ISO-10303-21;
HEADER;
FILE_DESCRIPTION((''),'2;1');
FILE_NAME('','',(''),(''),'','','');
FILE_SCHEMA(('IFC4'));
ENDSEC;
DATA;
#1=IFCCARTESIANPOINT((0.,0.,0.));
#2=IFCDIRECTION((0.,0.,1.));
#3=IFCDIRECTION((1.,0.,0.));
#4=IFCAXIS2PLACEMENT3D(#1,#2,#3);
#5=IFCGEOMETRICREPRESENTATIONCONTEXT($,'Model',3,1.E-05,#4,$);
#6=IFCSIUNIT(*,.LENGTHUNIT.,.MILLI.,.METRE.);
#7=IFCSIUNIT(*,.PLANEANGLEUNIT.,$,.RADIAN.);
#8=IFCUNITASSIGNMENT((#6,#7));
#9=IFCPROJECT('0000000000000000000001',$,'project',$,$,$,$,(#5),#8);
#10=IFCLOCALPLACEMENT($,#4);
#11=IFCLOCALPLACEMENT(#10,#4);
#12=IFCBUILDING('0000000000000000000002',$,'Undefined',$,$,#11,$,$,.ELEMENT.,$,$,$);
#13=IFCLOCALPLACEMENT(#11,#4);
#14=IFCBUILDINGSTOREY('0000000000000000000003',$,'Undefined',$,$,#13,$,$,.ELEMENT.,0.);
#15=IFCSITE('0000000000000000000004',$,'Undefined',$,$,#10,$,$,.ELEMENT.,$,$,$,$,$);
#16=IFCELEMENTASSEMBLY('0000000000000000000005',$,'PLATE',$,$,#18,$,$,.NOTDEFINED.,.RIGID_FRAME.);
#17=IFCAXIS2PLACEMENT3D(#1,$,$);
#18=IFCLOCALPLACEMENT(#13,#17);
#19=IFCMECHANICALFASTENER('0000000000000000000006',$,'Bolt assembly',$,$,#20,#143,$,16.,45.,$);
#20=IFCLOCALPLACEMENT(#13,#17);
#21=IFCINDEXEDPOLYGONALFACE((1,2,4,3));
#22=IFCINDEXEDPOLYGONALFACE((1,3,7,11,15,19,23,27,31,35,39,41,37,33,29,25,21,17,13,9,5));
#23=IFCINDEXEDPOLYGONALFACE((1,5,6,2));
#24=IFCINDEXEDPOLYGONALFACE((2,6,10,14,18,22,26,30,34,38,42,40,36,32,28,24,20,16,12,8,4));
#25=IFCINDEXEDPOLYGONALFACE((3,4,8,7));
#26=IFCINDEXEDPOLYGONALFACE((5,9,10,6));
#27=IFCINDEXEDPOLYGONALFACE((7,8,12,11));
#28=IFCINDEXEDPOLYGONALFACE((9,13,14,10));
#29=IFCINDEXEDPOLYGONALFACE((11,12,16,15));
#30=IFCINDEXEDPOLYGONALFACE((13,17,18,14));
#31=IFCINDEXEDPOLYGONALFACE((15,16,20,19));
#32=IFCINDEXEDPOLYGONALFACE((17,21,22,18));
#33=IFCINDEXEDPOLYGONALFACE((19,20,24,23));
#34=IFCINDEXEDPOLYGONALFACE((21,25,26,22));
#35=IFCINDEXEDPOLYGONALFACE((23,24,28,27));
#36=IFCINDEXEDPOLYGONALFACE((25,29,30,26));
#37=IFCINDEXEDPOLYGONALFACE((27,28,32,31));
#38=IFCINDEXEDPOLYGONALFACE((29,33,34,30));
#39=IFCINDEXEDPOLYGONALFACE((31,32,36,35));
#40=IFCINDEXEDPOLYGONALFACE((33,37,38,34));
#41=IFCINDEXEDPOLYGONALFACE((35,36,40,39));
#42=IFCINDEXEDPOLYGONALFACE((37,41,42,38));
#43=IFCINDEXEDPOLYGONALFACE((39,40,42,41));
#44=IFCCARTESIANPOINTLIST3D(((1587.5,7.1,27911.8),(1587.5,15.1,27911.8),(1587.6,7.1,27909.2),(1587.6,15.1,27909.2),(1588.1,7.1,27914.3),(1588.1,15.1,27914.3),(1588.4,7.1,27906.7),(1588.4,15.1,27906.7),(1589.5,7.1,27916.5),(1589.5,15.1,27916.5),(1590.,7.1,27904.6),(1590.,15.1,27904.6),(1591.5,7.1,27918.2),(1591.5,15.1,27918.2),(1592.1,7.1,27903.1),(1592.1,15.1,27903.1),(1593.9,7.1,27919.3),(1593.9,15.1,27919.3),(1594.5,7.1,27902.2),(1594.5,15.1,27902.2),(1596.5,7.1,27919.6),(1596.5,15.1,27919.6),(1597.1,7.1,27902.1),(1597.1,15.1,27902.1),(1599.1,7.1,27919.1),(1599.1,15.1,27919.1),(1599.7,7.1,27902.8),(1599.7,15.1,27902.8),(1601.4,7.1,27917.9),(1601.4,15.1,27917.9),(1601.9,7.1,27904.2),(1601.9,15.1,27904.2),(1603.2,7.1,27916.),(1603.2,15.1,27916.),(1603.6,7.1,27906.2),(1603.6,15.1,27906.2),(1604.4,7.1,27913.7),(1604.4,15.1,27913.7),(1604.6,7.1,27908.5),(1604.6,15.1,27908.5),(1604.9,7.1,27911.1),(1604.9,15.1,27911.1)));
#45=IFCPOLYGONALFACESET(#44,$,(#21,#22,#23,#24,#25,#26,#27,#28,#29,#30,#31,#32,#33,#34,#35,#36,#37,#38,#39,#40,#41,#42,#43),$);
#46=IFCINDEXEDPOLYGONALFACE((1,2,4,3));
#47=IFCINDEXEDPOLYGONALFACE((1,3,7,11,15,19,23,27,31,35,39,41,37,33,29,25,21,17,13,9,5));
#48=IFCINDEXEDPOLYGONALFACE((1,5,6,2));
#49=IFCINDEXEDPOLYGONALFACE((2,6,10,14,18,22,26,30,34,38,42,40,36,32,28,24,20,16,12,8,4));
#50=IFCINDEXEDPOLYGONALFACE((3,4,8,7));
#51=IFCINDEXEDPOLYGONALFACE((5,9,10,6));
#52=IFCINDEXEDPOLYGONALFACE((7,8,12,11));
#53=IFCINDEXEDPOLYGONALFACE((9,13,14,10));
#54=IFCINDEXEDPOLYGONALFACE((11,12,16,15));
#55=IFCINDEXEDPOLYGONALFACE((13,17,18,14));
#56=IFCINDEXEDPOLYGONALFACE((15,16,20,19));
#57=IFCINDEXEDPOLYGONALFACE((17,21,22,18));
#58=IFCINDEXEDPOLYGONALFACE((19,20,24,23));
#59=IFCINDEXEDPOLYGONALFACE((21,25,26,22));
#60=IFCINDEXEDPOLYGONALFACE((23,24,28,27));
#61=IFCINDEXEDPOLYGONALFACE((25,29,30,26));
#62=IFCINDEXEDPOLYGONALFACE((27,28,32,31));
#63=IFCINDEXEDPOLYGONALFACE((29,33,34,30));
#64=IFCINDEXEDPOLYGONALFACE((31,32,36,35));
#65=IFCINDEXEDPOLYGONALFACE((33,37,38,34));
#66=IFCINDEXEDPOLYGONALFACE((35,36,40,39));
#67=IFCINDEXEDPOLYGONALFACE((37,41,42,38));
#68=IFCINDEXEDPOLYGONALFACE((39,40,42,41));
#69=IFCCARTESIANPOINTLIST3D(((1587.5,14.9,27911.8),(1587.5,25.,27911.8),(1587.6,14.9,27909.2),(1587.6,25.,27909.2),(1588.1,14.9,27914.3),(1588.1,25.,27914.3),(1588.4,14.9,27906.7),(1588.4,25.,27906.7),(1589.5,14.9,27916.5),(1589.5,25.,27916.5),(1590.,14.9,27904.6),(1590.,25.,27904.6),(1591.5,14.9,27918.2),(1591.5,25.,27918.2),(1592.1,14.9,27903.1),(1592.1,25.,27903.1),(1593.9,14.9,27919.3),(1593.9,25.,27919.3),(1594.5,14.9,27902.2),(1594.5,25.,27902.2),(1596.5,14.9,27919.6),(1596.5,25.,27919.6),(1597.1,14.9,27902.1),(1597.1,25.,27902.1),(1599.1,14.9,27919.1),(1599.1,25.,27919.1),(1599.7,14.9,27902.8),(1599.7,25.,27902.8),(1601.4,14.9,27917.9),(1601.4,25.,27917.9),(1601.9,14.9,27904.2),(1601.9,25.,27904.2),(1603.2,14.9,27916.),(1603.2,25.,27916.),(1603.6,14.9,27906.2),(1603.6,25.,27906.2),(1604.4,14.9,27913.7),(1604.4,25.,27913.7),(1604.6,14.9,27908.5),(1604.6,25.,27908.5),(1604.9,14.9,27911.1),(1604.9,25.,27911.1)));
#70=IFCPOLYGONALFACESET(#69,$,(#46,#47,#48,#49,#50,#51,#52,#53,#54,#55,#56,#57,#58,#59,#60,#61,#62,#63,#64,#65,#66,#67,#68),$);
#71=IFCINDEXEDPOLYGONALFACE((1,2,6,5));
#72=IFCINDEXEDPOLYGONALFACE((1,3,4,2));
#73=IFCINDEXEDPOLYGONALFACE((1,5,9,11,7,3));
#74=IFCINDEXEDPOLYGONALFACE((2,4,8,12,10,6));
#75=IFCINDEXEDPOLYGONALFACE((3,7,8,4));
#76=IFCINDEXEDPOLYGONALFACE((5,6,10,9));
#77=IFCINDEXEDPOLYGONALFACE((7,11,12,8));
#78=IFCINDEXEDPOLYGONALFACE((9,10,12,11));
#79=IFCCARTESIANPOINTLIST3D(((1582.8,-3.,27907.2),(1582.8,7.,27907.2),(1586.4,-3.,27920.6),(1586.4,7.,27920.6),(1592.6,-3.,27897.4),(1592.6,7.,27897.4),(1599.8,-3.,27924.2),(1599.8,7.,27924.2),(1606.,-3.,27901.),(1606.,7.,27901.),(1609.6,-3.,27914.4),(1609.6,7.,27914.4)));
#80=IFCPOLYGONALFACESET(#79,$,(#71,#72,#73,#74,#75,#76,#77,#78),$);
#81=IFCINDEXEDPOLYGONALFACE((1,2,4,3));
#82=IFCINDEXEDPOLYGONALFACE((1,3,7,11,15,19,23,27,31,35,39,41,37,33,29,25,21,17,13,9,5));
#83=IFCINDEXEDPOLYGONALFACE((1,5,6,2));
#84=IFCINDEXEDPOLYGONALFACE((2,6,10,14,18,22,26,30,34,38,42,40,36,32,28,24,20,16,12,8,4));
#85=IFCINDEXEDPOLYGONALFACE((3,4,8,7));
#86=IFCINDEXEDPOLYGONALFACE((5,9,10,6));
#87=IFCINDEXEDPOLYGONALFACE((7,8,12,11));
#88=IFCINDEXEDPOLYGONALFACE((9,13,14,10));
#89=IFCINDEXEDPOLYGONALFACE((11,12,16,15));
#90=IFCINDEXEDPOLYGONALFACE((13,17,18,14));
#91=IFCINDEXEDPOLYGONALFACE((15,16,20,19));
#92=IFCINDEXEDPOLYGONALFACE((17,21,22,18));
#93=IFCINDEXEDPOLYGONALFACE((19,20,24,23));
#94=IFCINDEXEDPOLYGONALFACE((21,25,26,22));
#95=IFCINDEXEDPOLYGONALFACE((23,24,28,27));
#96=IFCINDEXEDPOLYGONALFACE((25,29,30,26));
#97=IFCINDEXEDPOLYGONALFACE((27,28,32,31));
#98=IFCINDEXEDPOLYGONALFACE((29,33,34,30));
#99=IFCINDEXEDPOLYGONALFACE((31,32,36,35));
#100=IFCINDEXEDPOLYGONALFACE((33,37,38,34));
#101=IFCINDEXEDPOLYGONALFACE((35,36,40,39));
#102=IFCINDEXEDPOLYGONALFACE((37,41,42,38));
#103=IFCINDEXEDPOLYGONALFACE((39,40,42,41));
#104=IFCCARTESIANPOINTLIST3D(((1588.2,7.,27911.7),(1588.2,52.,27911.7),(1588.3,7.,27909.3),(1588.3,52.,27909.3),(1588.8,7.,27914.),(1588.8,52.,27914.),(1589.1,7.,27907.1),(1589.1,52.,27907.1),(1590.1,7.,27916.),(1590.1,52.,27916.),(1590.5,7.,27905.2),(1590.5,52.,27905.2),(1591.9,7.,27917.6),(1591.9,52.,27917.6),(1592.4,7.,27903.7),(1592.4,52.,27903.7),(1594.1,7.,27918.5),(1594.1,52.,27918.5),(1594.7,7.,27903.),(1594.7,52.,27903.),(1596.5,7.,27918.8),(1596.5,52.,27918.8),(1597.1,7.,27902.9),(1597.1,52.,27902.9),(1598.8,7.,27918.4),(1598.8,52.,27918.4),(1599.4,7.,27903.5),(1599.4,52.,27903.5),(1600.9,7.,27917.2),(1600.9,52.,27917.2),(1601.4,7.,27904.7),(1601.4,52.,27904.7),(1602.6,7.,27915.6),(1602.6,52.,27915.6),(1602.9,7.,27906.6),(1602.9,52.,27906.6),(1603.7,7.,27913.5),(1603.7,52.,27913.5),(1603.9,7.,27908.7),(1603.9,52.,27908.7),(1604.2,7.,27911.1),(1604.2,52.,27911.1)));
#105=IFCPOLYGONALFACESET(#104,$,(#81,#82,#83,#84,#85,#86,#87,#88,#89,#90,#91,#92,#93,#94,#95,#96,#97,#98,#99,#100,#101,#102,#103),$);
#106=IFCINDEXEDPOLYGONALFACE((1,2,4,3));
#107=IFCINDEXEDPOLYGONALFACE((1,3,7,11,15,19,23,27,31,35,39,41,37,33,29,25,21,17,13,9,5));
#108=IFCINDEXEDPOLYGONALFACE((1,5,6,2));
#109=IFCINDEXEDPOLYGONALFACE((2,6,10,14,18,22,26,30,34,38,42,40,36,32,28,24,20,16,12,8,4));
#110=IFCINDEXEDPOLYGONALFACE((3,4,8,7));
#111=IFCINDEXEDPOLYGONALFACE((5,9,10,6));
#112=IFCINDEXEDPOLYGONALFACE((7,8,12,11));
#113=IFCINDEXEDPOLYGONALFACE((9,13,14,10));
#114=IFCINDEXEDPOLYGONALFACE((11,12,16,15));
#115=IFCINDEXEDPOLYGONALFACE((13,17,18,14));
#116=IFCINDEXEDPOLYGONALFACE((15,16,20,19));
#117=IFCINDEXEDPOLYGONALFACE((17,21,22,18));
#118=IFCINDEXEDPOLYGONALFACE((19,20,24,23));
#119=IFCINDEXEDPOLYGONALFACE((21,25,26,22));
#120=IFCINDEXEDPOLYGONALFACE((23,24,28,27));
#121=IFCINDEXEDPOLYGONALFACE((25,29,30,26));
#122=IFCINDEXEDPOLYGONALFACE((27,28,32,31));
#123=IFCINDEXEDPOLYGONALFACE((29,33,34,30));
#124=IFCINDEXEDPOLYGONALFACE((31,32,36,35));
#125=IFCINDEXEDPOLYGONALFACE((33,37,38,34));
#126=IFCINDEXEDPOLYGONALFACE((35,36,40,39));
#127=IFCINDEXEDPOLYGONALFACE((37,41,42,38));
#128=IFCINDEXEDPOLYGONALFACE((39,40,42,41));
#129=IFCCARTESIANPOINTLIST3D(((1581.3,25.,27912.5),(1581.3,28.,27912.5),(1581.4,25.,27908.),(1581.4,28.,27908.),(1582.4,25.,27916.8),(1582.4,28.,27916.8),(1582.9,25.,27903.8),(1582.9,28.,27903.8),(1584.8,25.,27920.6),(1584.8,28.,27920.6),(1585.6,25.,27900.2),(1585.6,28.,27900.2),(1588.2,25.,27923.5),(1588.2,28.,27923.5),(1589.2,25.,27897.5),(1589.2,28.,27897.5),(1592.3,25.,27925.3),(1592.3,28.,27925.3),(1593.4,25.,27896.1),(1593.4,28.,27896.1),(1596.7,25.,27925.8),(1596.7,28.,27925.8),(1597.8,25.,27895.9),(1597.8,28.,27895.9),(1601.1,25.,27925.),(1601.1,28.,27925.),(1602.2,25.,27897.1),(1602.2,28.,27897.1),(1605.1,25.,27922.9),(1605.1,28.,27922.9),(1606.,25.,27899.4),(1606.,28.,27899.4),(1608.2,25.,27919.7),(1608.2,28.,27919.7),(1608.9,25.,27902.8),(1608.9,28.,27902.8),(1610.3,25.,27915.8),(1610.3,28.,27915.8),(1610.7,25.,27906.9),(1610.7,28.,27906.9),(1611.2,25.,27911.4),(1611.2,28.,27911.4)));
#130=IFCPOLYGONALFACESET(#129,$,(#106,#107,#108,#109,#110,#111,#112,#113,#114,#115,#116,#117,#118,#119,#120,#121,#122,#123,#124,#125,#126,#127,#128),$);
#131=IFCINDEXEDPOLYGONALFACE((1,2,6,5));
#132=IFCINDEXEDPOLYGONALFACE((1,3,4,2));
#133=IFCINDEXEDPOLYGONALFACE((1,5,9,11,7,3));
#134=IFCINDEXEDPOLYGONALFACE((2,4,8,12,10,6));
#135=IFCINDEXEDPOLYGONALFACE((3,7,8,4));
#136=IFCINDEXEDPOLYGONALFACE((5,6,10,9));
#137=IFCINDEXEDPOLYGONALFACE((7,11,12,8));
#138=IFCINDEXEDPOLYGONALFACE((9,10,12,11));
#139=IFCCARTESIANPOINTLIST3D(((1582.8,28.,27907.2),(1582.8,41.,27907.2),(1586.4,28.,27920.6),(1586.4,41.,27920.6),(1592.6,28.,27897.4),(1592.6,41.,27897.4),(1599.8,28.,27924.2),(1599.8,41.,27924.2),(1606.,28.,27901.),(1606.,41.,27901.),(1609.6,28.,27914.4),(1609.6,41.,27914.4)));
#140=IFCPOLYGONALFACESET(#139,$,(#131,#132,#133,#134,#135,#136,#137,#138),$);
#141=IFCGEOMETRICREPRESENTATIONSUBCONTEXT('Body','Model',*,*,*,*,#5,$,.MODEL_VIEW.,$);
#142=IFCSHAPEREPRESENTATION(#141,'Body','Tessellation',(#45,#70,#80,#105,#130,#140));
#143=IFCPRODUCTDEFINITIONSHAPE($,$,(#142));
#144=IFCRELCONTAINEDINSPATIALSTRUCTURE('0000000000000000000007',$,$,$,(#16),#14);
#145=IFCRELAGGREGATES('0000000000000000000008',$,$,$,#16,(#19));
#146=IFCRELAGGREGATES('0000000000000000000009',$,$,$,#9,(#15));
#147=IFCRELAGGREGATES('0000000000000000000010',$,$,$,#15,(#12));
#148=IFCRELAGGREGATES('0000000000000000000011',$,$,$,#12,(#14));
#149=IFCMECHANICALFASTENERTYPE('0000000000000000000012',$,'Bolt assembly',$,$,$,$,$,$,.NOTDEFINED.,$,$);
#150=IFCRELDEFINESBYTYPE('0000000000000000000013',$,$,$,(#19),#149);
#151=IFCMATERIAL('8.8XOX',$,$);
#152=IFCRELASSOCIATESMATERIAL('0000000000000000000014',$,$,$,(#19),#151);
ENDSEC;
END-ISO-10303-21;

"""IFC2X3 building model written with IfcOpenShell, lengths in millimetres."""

from ifc_helpers import new_model, si_unit, frame, origin_with_axes, origin_2d_with_axis, place, context, subcontext, project, spatial, polyline, circle, outline, extrude, source, transform, mapped, material, type_object, element, aggregate, save


model = new_model("IFC2X3")

# Units and contexts
model_context = context("Model", 3, precision=1e-05, world=origin_with_axes())
body_context = subcontext(model_context, "Body", "Model", "MODEL_VIEW")
ifc_project = project(units=[si_unit("LENGTHUNIT", "METRE", prefix="MILLI"), si_unit("PLANEANGLEUNIT", "RADIAN")], contexts=[model_context])

# Site, building, storey
site_placement = place(None, origin_with_axes())
site = spatial("IfcSite", under=ifc_project, at=site_placement, Name="Undefined", CompositionType="ELEMENT")
building_placement = place(site_placement, origin_with_axes())
building = spatial("IfcBuilding", under=site, at=building_placement, Name="Undefined", CompositionType="ELEMENT")
storey_placement = place(building_placement, origin_with_axes())
storey = spatial("IfcBuildingStorey", under=building, at=storey_placement, Name="Undefined", CompositionType="ELEMENT", Elevation=0.0)

# Element assembly
assembly_1_placement = place(storey_placement, origin_with_axes())
assembly_1 = element("IfcElementAssembly", 1, at=assembly_1_placement, inside=storey, Name="PLATE", AssemblyPlace="NOTDEFINED", PredefinedType="RIGID_FRAME")

# Shared definitions
ifc_material_1 = material(Name="8.8XOX")
mechanical_fastener_type = type_object("IfcMechanicalFastenerType", Name="Bolt assembly")
shared_shape = source(origin_with_axes(), body_context, "Body", "SweptSolid", [
    extrude(circle(Radius=8.8, at=origin_2d_with_axis()), frame((0.0, 7.1, 0.0), z_axis=(0.0, 1.0, 0.0), x_axis=(1.0, 0.0, 0.0)), (0.0, 0.0, 1.0), 8.0),
    extrude(circle(Radius=8.8, at=origin_2d_with_axis()), frame((0.0, 14.9, 0.0), z_axis=(0.0, 1.0, 0.0), x_axis=(1.0, 0.0, 0.0)), (0.0, 0.0, 1.0), 10.1),
    extrude(outline(polyline([(12.0, -6.9), (12.0, 6.9), (0.0, 13.9), (-12.0, 6.9), (-12.0, -6.9), (0.0, -13.9), (12.0, -6.9)])), frame((0.0, -3.0, 0.0), z_axis=(0.0, 1.0, 0.0), x_axis=(1.0, 0.0, 0.0)), (0.0, 0.0, 1.0), 10.0),
    extrude(circle(Radius=8.0, at=origin_2d_with_axis()), frame((0.0, 7.0, 0.0), z_axis=(0.0, 1.0, 0.0), x_axis=(1.0, 0.0, 0.0)), (0.0, 0.0, 1.0), 45.0),
    extrude(circle(Radius=15.0, at=origin_2d_with_axis()), frame((0.0, 25.0, 0.0), z_axis=(0.0, 1.0, 0.0), x_axis=(1.0, 0.0, 0.0)), (0.0, 0.0, 1.0), 3.0),
    extrude(outline(polyline([(12.0, -6.9), (12.0, 6.9), (0.0, 13.9), (-12.0, 6.9), (-12.0, -6.9), (0.0, -13.9), (12.0, -6.9)])), frame((0.0, 28.0, 0.0), z_axis=(0.0, 1.0, 0.0), x_axis=(1.0, 0.0, 0.0)), (0.0, 0.0, 1.0), 13.0),
])

# Mechanical fastener
mechanical_fastener_1_placement = place(assembly_1_placement, frame((1596.2, 0.0, 27910.8), z_axis=(0.707107, 0.0, -0.707107), x_axis=(-0.707107, 0.0, -0.707107)))
mechanical_fastener_1 = element("IfcMechanicalFastener", 2, at=mechanical_fastener_1_placement, type_object=mechanical_fastener_type, material=ifc_material_1, Name="Bolt assembly", NominalDiameter=16.0, NominalLength=45.0, context=body_context, shape_type="MappedRepresentation", body=[
    mapped(shared_shape, transform((0.0, 0.0, 0.0))),
])
aggregate(assembly_1, [mechanical_fastener_1])

save(model, "model.ifc")
